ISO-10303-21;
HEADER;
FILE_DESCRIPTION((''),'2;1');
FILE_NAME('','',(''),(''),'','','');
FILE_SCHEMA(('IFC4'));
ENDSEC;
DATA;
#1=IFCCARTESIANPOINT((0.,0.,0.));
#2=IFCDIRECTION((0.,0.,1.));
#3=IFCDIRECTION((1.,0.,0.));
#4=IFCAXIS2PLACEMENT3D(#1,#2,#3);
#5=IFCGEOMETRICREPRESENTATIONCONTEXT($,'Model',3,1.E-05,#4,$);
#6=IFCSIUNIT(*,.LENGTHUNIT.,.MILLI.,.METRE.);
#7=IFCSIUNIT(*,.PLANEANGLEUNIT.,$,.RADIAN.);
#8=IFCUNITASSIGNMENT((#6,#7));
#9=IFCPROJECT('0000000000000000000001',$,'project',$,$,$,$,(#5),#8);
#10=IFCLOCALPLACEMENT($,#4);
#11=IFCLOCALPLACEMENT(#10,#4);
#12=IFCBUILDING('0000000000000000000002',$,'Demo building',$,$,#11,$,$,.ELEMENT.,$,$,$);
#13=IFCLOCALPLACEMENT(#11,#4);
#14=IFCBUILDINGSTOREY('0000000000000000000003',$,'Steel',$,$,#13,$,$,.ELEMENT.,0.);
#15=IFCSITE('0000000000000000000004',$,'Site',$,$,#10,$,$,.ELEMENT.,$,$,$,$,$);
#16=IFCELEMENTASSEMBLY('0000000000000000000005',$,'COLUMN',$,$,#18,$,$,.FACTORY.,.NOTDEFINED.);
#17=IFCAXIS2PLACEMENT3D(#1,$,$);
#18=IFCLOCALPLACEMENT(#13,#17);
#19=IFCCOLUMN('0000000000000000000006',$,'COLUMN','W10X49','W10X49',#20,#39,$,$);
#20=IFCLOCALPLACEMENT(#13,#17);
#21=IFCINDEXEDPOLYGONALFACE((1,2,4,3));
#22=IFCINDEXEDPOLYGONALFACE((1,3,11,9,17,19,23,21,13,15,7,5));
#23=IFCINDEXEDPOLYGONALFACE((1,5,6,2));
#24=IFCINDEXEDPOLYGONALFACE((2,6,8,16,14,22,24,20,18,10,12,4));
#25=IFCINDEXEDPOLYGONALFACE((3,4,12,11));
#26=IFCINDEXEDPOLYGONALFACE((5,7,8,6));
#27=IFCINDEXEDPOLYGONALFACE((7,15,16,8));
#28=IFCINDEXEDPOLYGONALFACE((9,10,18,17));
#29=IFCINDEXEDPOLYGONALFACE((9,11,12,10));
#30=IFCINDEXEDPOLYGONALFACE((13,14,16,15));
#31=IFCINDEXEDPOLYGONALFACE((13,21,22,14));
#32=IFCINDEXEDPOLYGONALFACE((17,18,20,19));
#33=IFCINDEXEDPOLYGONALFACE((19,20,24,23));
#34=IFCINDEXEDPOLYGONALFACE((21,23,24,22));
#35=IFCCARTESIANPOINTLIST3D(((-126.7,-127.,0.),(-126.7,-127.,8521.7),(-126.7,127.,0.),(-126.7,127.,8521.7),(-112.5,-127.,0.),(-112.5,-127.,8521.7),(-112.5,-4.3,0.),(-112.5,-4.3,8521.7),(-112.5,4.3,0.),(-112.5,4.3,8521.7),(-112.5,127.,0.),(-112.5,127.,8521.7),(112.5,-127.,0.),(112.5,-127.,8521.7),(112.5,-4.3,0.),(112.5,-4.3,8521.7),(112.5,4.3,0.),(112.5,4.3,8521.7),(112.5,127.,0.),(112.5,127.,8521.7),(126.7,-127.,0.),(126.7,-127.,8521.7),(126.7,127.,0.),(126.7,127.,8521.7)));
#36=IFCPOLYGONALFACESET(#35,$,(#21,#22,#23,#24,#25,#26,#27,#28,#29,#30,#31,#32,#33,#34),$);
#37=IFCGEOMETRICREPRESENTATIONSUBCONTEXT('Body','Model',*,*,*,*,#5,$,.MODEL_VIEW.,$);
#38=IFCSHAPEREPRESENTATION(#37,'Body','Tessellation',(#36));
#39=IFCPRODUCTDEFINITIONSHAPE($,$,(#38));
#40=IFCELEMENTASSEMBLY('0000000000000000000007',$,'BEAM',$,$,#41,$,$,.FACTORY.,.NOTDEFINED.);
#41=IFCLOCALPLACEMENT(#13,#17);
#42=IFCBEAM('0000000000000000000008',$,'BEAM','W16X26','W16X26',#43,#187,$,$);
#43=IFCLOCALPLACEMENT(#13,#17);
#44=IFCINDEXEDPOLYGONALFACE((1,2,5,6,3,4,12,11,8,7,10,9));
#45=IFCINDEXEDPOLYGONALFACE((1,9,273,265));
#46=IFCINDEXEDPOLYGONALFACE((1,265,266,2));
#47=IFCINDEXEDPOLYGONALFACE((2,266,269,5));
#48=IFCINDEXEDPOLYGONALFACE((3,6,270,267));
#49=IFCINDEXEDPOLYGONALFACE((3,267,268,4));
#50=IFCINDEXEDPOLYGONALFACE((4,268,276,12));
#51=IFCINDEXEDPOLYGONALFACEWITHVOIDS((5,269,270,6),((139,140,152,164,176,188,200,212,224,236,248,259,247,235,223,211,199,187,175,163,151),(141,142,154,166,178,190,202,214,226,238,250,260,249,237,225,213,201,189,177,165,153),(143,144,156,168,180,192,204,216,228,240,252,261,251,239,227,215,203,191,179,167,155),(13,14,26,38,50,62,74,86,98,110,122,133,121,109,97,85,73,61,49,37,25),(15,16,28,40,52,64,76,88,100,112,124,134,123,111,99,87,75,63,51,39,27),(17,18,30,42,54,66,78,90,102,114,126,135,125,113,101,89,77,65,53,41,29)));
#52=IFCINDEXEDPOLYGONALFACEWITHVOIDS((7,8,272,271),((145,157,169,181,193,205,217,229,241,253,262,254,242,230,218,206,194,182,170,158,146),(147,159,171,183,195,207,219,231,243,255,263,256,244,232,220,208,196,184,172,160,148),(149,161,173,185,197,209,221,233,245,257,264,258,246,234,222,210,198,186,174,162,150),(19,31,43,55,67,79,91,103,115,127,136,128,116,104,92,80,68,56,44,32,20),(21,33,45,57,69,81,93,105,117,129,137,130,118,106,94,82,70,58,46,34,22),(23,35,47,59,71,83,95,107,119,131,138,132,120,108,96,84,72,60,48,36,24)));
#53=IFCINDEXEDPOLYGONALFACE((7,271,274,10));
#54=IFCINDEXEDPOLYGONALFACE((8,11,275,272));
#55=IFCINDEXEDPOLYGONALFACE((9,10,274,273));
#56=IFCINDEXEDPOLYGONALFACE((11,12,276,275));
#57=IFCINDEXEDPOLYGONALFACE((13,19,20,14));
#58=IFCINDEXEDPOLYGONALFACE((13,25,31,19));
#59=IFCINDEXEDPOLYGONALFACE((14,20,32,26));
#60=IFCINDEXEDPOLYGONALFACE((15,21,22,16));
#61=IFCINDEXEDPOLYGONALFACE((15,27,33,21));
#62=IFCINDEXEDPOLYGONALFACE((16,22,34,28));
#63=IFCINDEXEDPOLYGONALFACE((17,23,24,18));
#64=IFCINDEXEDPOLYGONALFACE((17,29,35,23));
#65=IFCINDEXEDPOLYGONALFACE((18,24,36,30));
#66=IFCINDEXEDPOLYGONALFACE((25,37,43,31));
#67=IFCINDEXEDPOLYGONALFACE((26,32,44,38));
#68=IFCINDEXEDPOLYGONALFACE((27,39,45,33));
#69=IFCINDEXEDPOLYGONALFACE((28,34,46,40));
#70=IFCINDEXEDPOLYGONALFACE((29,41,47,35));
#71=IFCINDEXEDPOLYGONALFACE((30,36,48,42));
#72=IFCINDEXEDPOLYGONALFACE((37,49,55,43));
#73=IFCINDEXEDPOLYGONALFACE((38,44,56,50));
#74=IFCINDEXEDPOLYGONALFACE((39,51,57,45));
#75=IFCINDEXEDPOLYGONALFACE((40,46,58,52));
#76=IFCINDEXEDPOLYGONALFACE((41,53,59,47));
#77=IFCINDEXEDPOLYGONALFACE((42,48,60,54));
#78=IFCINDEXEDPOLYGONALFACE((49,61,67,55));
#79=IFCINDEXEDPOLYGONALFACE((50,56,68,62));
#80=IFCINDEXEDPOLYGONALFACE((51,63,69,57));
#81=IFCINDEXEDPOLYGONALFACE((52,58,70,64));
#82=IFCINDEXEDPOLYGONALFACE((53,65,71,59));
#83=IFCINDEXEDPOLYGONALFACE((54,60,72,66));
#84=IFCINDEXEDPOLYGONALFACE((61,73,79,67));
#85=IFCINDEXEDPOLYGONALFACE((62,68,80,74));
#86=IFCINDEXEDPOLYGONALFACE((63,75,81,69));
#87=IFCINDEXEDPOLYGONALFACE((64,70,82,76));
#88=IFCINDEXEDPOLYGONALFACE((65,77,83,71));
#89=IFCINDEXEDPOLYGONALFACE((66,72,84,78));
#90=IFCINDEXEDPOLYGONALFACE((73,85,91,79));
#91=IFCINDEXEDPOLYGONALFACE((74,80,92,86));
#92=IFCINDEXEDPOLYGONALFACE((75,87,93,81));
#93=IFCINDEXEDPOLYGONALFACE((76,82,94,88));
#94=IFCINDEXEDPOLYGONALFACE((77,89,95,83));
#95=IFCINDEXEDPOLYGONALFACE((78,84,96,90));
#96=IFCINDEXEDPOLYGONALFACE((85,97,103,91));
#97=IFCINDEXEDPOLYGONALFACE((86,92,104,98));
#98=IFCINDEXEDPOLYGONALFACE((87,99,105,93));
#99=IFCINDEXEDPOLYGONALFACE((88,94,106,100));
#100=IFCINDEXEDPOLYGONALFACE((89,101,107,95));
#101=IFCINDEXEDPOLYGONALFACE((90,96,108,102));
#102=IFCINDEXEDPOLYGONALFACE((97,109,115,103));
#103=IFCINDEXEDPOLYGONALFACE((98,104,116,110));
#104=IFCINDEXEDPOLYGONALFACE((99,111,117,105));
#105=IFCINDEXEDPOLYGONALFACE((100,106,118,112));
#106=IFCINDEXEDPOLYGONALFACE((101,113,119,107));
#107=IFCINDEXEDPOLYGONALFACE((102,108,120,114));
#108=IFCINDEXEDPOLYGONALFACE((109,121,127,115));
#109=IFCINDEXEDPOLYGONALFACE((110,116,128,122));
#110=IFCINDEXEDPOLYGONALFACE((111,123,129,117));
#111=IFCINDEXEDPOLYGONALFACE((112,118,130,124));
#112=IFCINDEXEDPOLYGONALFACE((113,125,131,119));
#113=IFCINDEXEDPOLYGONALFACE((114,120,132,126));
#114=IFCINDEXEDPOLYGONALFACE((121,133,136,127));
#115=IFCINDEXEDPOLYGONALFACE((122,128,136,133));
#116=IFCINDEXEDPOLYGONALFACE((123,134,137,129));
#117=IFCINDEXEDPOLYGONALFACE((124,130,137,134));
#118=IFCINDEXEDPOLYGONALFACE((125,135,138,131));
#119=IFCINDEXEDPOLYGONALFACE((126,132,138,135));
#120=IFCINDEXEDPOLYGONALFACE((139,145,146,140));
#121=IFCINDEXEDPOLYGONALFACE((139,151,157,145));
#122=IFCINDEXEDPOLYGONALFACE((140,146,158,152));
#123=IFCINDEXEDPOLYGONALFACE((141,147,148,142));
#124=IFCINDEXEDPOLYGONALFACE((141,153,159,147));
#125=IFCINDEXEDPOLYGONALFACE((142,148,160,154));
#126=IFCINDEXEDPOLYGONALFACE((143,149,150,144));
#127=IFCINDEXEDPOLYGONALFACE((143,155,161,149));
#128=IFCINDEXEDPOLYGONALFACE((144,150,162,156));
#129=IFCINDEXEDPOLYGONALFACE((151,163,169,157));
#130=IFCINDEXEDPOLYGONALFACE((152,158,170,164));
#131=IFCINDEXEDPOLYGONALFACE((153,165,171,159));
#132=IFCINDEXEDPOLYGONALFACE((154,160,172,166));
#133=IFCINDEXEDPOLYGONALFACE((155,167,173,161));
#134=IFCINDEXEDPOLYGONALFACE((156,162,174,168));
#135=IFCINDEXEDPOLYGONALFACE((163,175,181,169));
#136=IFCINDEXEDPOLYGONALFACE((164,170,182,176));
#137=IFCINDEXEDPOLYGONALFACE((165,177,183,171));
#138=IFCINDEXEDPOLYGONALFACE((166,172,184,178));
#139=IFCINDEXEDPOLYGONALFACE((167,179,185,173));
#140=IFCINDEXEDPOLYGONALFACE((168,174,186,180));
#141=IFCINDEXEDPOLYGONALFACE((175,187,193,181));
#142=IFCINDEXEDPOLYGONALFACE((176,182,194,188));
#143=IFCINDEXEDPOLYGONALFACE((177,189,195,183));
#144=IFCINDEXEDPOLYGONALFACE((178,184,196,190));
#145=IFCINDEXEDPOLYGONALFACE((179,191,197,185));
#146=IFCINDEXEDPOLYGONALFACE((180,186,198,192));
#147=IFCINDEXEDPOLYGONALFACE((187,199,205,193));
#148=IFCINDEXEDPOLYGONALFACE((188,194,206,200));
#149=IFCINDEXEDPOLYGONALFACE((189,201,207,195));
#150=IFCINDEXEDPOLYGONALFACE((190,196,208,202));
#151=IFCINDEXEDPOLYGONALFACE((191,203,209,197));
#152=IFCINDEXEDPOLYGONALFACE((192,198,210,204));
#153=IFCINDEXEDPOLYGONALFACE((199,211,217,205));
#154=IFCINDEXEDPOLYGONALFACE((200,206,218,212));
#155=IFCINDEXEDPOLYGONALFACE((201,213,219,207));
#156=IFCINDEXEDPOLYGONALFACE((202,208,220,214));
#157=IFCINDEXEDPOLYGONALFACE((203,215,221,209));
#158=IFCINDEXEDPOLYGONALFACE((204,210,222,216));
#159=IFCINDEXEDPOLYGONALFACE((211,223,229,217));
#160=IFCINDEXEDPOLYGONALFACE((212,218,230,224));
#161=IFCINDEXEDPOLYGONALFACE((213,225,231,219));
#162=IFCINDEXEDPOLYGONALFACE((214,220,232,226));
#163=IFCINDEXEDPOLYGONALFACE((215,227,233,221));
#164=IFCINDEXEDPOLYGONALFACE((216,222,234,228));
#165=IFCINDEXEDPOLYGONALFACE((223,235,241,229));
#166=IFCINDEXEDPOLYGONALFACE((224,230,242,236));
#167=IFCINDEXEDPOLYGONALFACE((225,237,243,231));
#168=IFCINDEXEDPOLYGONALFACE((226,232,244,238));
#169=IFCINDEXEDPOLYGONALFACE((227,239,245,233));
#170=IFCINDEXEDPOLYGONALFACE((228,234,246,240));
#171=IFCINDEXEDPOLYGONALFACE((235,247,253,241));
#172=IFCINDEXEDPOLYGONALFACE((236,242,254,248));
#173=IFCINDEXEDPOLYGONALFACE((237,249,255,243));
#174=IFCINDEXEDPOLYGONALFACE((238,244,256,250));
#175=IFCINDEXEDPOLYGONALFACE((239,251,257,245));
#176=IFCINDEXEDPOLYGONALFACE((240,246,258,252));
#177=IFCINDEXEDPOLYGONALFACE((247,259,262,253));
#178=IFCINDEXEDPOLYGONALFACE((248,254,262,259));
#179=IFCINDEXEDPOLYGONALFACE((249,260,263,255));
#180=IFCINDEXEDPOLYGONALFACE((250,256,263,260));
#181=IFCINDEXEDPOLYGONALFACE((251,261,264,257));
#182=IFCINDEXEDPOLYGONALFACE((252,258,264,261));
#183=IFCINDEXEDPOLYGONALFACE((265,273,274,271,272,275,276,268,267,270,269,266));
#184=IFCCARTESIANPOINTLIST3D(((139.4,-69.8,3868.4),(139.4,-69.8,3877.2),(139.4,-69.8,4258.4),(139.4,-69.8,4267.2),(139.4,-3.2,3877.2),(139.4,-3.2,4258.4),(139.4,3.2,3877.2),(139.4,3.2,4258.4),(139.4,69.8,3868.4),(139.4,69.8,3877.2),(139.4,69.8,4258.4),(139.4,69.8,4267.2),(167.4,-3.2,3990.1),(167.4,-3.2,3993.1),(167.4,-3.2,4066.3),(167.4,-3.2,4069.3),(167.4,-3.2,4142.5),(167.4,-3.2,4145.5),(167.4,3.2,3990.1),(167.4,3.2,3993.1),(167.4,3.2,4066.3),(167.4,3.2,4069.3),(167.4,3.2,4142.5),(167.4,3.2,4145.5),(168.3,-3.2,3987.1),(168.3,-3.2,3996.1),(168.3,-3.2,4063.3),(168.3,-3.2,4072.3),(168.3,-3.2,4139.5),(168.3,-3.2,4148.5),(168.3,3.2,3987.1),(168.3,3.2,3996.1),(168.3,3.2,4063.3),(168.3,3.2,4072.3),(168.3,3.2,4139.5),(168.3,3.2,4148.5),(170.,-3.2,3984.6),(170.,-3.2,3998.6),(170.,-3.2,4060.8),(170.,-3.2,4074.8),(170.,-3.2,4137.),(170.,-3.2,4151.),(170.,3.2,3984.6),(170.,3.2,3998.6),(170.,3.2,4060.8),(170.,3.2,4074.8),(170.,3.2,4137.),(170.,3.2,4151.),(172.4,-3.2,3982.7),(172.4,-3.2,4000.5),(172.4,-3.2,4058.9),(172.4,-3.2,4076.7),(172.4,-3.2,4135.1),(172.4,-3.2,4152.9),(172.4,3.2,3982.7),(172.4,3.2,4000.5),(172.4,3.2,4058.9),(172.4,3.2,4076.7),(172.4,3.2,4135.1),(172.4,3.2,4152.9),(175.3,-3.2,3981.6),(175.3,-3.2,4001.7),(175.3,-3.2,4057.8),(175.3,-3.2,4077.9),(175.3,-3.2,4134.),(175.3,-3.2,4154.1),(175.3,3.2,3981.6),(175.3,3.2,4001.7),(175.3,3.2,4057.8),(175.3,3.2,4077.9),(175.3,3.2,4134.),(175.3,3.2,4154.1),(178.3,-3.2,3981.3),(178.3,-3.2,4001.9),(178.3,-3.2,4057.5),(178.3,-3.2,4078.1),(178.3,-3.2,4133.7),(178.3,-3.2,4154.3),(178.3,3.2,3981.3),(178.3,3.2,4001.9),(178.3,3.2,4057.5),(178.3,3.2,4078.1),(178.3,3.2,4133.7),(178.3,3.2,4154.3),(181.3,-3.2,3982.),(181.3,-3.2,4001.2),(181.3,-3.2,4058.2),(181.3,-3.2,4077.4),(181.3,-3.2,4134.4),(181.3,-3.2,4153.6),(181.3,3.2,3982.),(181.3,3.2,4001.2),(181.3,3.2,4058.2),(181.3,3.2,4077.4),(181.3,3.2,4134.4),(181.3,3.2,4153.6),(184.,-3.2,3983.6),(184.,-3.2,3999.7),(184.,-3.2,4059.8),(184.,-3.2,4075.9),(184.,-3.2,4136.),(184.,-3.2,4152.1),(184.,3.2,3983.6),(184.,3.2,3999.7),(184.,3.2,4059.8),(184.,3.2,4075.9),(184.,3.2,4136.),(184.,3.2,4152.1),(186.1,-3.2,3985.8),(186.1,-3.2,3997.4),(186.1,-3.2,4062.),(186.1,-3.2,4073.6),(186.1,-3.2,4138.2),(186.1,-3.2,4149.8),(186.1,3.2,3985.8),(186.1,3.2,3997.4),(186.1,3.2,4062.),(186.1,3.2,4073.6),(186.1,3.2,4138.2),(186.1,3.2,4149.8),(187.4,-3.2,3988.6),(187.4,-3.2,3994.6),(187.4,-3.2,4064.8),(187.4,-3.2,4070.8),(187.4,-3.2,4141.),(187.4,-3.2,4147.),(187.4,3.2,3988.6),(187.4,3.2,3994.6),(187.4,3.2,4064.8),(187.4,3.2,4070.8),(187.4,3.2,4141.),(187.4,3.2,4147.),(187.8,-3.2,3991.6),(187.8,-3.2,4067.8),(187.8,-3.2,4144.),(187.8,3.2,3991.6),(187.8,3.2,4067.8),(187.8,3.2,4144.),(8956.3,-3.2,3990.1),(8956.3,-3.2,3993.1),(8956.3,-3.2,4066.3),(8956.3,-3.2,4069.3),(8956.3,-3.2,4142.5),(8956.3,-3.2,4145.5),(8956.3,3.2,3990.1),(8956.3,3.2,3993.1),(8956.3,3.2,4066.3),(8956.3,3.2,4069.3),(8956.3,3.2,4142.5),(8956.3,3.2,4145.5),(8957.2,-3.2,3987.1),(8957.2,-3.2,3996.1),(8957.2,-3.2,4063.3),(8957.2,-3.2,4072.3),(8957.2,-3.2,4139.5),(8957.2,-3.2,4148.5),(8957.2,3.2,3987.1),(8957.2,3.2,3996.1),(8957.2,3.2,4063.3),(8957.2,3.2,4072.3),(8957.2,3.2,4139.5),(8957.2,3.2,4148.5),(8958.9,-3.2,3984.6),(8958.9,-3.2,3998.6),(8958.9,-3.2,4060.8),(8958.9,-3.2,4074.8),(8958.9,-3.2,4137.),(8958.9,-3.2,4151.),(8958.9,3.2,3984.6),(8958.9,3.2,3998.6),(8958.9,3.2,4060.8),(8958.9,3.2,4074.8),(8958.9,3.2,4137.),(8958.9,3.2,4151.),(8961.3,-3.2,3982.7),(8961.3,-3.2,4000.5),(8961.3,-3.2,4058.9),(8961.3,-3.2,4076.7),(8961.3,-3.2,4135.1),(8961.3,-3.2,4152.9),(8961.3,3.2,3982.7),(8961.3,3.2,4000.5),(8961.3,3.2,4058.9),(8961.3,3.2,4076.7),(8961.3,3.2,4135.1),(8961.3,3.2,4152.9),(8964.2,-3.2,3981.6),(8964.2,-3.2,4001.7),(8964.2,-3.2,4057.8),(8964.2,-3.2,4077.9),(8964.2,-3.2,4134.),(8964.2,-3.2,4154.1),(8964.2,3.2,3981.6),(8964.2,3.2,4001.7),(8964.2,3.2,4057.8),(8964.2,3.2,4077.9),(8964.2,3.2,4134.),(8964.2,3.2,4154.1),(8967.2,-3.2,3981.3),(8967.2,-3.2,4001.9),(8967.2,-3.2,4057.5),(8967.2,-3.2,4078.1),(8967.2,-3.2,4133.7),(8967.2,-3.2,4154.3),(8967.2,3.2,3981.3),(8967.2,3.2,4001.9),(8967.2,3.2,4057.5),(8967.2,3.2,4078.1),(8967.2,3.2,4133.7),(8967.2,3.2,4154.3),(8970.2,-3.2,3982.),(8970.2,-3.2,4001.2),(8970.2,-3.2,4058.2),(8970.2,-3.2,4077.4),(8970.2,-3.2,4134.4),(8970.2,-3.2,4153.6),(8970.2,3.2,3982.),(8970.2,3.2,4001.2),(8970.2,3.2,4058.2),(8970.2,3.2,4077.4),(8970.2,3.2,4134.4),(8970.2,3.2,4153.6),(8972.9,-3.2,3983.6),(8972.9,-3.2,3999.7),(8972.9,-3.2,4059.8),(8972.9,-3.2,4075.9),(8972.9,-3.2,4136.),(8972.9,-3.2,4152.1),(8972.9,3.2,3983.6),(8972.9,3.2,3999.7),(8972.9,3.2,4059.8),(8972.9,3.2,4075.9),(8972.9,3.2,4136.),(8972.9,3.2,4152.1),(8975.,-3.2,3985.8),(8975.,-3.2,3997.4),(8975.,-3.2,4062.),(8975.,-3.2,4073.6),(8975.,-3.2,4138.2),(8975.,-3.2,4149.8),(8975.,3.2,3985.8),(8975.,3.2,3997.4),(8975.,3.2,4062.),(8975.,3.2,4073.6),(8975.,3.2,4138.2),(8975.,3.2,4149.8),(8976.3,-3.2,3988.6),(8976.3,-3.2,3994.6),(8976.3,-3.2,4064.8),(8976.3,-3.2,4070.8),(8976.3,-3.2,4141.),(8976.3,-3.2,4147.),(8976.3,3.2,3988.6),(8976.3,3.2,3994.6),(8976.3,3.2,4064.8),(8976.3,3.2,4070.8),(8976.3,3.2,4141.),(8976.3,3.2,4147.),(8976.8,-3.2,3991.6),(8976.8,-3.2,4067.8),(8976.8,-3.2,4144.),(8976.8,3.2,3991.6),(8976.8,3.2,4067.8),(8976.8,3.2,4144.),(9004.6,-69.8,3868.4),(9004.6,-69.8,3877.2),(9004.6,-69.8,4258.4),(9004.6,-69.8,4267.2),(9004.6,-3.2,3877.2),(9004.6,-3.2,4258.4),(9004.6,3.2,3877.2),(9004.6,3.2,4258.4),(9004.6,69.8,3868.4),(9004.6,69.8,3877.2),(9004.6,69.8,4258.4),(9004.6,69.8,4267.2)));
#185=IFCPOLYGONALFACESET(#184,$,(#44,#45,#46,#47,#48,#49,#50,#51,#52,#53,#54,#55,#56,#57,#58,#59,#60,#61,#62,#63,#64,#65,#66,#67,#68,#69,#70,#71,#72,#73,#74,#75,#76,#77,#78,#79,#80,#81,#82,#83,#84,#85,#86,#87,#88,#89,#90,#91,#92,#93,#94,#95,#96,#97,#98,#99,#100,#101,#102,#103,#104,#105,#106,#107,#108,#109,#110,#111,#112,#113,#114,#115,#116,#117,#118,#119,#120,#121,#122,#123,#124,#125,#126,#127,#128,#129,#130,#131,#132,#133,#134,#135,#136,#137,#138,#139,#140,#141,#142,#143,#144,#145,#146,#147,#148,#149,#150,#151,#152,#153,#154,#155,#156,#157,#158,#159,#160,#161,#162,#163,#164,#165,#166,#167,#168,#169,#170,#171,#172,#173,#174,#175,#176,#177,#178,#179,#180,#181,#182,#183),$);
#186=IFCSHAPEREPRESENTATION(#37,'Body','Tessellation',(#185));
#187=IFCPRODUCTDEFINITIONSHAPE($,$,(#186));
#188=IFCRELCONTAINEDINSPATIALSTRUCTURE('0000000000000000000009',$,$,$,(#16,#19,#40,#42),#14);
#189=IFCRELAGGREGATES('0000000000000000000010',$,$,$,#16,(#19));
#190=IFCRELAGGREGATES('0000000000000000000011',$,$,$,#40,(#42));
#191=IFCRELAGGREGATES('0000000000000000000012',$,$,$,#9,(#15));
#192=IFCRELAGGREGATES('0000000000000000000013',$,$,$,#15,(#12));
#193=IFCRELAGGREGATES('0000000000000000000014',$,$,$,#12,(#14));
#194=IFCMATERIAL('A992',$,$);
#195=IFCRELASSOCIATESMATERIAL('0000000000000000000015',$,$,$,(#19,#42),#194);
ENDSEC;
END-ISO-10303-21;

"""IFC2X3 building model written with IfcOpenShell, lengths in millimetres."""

from ifc_helpers import new_model, si_unit, frame, origin, origin_with_axes, origin_2d, place, context, subcontext, project, spatial, circle, i_section, extrude, boolean, material, element, aggregate, save


model = new_model("IFC2X3")

# Units and contexts
model_context = context("Model", 3, precision=1e-05, world=origin_with_axes())
body_context = subcontext(model_context, "Body", "Model", "MODEL_VIEW")
ifc_project = project(units=[si_unit("LENGTHUNIT", "METRE", prefix="MILLI"), si_unit("PLANEANGLEUNIT", "RADIAN")], contexts=[model_context])

# Site, building, storey
site_placement = place(None, origin_with_axes())
site = spatial("IfcSite", under=ifc_project, at=site_placement, Name="Site", CompositionType="ELEMENT")
building_placement = place(site_placement, origin_with_axes())
building = spatial("IfcBuilding", under=site, at=building_placement, Name="Demo building", CompositionType="ELEMENT")
placement = place(building_placement, origin_with_axes())
storey = spatial("IfcBuildingStorey", under=building, at=placement, Name="Steel", CompositionType="ELEMENT", Elevation=0.0)

# Element assembly, column
assembly_1 = element("IfcElementAssembly", 1, at=placement, inside=storey, Name="COLUMN", AssemblyPlace="FACTORY", PredefinedType="NOTDEFINED")
ifc_material_1 = material(Name="A992")
column_placement = place(placement, frame((0.0, 0.0, 0.0), z_axis=(0.0, 0.0, 1.0), x_axis=(0.0, -1.0, 0.0)))
column = element("IfcColumn", 2, at=column_placement, inside=storey, material=ifc_material_1, Name="COLUMN", Description="W10X49", ObjectType="W10X49", context=body_context, shape_type="SweptSolid", body=[
    extrude(i_section(OverallWidth=254.0, OverallDepth=253.5, WebThickness=8.6, FlangeThickness=14.2, at=origin_2d()), origin(), (0.0, 0.0, 1.0), 8521.7),
])

# Element assembly, beam
assembly_2 = element("IfcElementAssembly", 3, at=placement, inside=storey, Name="BEAM", AssemblyPlace="FACTORY", PredefinedType="NOTDEFINED")
beam_1_placement = place(placement, frame((139.4, 0.0, 4067.8), z_axis=(1.0, 0.0, 0.0), x_axis=(0.0, 1.0, 0.0)))
beam_1 = element("IfcBeam", 4, at=beam_1_placement, inside=storey, material=ifc_material_1, Name="BEAM", Description="W16X26", ObjectType="W16X26", context=body_context, shape_type="CSG", body=[
    boolean("DIFFERENCE", boolean("DIFFERENCE", boolean("DIFFERENCE", boolean("DIFFERENCE", boolean("DIFFERENCE", boolean("DIFFERENCE", extrude(i_section(OverallWidth=139.7, OverallDepth=398.8, WebThickness=6.3, FlangeThickness=8.8, at=origin_2d()), origin(), (0.0, 0.0, 1.0), 8865.1), extrude(circle(Radius=10.3, at=origin_2d()), frame((-60.0, -76.2, 38.1), z_axis=(1.0, 0.0, 0.0), x_axis=(0.0, 0.0, 1.0)), (0.0, 0.0, 1.0), 120.0)), extrude(circle(Radius=10.3, at=origin_2d()), frame((-60.0, 0.0, 38.1), z_axis=(1.0, 0.0, 0.0), x_axis=(0.0, 0.0, 1.0)), (0.0, 0.0, 1.0), 120.0)), extrude(circle(Radius=10.3, at=origin_2d()), frame((-60.0, 76.2, 38.1), z_axis=(1.0, 0.0, 0.0), x_axis=(0.0, 0.0, 1.0)), (0.0, 0.0, 1.0), 120.0)), extrude(circle(Radius=10.3, at=origin_2d()), frame((-60.0, -76.2, 8827.0), z_axis=(1.0, 0.0, 0.0), x_axis=(0.0, 0.0, 1.0)), (0.0, 0.0, 1.0), 120.0)), extrude(circle(Radius=10.3, at=origin_2d()), frame((-60.0, 0.0, 8827.0), z_axis=(1.0, 0.0, 0.0), x_axis=(0.0, 0.0, 1.0)), (0.0, 0.0, 1.0), 120.0)), extrude(circle(Radius=10.3, at=origin_2d()), frame((-60.0, 76.2, 8827.0), z_axis=(1.0, 0.0, 0.0), x_axis=(0.0, 0.0, 1.0)), (0.0, 0.0, 1.0), 120.0)),
])

aggregate(assembly_1, [column])

aggregate(assembly_2, [beam_1])

save(model, "model.ifc")
